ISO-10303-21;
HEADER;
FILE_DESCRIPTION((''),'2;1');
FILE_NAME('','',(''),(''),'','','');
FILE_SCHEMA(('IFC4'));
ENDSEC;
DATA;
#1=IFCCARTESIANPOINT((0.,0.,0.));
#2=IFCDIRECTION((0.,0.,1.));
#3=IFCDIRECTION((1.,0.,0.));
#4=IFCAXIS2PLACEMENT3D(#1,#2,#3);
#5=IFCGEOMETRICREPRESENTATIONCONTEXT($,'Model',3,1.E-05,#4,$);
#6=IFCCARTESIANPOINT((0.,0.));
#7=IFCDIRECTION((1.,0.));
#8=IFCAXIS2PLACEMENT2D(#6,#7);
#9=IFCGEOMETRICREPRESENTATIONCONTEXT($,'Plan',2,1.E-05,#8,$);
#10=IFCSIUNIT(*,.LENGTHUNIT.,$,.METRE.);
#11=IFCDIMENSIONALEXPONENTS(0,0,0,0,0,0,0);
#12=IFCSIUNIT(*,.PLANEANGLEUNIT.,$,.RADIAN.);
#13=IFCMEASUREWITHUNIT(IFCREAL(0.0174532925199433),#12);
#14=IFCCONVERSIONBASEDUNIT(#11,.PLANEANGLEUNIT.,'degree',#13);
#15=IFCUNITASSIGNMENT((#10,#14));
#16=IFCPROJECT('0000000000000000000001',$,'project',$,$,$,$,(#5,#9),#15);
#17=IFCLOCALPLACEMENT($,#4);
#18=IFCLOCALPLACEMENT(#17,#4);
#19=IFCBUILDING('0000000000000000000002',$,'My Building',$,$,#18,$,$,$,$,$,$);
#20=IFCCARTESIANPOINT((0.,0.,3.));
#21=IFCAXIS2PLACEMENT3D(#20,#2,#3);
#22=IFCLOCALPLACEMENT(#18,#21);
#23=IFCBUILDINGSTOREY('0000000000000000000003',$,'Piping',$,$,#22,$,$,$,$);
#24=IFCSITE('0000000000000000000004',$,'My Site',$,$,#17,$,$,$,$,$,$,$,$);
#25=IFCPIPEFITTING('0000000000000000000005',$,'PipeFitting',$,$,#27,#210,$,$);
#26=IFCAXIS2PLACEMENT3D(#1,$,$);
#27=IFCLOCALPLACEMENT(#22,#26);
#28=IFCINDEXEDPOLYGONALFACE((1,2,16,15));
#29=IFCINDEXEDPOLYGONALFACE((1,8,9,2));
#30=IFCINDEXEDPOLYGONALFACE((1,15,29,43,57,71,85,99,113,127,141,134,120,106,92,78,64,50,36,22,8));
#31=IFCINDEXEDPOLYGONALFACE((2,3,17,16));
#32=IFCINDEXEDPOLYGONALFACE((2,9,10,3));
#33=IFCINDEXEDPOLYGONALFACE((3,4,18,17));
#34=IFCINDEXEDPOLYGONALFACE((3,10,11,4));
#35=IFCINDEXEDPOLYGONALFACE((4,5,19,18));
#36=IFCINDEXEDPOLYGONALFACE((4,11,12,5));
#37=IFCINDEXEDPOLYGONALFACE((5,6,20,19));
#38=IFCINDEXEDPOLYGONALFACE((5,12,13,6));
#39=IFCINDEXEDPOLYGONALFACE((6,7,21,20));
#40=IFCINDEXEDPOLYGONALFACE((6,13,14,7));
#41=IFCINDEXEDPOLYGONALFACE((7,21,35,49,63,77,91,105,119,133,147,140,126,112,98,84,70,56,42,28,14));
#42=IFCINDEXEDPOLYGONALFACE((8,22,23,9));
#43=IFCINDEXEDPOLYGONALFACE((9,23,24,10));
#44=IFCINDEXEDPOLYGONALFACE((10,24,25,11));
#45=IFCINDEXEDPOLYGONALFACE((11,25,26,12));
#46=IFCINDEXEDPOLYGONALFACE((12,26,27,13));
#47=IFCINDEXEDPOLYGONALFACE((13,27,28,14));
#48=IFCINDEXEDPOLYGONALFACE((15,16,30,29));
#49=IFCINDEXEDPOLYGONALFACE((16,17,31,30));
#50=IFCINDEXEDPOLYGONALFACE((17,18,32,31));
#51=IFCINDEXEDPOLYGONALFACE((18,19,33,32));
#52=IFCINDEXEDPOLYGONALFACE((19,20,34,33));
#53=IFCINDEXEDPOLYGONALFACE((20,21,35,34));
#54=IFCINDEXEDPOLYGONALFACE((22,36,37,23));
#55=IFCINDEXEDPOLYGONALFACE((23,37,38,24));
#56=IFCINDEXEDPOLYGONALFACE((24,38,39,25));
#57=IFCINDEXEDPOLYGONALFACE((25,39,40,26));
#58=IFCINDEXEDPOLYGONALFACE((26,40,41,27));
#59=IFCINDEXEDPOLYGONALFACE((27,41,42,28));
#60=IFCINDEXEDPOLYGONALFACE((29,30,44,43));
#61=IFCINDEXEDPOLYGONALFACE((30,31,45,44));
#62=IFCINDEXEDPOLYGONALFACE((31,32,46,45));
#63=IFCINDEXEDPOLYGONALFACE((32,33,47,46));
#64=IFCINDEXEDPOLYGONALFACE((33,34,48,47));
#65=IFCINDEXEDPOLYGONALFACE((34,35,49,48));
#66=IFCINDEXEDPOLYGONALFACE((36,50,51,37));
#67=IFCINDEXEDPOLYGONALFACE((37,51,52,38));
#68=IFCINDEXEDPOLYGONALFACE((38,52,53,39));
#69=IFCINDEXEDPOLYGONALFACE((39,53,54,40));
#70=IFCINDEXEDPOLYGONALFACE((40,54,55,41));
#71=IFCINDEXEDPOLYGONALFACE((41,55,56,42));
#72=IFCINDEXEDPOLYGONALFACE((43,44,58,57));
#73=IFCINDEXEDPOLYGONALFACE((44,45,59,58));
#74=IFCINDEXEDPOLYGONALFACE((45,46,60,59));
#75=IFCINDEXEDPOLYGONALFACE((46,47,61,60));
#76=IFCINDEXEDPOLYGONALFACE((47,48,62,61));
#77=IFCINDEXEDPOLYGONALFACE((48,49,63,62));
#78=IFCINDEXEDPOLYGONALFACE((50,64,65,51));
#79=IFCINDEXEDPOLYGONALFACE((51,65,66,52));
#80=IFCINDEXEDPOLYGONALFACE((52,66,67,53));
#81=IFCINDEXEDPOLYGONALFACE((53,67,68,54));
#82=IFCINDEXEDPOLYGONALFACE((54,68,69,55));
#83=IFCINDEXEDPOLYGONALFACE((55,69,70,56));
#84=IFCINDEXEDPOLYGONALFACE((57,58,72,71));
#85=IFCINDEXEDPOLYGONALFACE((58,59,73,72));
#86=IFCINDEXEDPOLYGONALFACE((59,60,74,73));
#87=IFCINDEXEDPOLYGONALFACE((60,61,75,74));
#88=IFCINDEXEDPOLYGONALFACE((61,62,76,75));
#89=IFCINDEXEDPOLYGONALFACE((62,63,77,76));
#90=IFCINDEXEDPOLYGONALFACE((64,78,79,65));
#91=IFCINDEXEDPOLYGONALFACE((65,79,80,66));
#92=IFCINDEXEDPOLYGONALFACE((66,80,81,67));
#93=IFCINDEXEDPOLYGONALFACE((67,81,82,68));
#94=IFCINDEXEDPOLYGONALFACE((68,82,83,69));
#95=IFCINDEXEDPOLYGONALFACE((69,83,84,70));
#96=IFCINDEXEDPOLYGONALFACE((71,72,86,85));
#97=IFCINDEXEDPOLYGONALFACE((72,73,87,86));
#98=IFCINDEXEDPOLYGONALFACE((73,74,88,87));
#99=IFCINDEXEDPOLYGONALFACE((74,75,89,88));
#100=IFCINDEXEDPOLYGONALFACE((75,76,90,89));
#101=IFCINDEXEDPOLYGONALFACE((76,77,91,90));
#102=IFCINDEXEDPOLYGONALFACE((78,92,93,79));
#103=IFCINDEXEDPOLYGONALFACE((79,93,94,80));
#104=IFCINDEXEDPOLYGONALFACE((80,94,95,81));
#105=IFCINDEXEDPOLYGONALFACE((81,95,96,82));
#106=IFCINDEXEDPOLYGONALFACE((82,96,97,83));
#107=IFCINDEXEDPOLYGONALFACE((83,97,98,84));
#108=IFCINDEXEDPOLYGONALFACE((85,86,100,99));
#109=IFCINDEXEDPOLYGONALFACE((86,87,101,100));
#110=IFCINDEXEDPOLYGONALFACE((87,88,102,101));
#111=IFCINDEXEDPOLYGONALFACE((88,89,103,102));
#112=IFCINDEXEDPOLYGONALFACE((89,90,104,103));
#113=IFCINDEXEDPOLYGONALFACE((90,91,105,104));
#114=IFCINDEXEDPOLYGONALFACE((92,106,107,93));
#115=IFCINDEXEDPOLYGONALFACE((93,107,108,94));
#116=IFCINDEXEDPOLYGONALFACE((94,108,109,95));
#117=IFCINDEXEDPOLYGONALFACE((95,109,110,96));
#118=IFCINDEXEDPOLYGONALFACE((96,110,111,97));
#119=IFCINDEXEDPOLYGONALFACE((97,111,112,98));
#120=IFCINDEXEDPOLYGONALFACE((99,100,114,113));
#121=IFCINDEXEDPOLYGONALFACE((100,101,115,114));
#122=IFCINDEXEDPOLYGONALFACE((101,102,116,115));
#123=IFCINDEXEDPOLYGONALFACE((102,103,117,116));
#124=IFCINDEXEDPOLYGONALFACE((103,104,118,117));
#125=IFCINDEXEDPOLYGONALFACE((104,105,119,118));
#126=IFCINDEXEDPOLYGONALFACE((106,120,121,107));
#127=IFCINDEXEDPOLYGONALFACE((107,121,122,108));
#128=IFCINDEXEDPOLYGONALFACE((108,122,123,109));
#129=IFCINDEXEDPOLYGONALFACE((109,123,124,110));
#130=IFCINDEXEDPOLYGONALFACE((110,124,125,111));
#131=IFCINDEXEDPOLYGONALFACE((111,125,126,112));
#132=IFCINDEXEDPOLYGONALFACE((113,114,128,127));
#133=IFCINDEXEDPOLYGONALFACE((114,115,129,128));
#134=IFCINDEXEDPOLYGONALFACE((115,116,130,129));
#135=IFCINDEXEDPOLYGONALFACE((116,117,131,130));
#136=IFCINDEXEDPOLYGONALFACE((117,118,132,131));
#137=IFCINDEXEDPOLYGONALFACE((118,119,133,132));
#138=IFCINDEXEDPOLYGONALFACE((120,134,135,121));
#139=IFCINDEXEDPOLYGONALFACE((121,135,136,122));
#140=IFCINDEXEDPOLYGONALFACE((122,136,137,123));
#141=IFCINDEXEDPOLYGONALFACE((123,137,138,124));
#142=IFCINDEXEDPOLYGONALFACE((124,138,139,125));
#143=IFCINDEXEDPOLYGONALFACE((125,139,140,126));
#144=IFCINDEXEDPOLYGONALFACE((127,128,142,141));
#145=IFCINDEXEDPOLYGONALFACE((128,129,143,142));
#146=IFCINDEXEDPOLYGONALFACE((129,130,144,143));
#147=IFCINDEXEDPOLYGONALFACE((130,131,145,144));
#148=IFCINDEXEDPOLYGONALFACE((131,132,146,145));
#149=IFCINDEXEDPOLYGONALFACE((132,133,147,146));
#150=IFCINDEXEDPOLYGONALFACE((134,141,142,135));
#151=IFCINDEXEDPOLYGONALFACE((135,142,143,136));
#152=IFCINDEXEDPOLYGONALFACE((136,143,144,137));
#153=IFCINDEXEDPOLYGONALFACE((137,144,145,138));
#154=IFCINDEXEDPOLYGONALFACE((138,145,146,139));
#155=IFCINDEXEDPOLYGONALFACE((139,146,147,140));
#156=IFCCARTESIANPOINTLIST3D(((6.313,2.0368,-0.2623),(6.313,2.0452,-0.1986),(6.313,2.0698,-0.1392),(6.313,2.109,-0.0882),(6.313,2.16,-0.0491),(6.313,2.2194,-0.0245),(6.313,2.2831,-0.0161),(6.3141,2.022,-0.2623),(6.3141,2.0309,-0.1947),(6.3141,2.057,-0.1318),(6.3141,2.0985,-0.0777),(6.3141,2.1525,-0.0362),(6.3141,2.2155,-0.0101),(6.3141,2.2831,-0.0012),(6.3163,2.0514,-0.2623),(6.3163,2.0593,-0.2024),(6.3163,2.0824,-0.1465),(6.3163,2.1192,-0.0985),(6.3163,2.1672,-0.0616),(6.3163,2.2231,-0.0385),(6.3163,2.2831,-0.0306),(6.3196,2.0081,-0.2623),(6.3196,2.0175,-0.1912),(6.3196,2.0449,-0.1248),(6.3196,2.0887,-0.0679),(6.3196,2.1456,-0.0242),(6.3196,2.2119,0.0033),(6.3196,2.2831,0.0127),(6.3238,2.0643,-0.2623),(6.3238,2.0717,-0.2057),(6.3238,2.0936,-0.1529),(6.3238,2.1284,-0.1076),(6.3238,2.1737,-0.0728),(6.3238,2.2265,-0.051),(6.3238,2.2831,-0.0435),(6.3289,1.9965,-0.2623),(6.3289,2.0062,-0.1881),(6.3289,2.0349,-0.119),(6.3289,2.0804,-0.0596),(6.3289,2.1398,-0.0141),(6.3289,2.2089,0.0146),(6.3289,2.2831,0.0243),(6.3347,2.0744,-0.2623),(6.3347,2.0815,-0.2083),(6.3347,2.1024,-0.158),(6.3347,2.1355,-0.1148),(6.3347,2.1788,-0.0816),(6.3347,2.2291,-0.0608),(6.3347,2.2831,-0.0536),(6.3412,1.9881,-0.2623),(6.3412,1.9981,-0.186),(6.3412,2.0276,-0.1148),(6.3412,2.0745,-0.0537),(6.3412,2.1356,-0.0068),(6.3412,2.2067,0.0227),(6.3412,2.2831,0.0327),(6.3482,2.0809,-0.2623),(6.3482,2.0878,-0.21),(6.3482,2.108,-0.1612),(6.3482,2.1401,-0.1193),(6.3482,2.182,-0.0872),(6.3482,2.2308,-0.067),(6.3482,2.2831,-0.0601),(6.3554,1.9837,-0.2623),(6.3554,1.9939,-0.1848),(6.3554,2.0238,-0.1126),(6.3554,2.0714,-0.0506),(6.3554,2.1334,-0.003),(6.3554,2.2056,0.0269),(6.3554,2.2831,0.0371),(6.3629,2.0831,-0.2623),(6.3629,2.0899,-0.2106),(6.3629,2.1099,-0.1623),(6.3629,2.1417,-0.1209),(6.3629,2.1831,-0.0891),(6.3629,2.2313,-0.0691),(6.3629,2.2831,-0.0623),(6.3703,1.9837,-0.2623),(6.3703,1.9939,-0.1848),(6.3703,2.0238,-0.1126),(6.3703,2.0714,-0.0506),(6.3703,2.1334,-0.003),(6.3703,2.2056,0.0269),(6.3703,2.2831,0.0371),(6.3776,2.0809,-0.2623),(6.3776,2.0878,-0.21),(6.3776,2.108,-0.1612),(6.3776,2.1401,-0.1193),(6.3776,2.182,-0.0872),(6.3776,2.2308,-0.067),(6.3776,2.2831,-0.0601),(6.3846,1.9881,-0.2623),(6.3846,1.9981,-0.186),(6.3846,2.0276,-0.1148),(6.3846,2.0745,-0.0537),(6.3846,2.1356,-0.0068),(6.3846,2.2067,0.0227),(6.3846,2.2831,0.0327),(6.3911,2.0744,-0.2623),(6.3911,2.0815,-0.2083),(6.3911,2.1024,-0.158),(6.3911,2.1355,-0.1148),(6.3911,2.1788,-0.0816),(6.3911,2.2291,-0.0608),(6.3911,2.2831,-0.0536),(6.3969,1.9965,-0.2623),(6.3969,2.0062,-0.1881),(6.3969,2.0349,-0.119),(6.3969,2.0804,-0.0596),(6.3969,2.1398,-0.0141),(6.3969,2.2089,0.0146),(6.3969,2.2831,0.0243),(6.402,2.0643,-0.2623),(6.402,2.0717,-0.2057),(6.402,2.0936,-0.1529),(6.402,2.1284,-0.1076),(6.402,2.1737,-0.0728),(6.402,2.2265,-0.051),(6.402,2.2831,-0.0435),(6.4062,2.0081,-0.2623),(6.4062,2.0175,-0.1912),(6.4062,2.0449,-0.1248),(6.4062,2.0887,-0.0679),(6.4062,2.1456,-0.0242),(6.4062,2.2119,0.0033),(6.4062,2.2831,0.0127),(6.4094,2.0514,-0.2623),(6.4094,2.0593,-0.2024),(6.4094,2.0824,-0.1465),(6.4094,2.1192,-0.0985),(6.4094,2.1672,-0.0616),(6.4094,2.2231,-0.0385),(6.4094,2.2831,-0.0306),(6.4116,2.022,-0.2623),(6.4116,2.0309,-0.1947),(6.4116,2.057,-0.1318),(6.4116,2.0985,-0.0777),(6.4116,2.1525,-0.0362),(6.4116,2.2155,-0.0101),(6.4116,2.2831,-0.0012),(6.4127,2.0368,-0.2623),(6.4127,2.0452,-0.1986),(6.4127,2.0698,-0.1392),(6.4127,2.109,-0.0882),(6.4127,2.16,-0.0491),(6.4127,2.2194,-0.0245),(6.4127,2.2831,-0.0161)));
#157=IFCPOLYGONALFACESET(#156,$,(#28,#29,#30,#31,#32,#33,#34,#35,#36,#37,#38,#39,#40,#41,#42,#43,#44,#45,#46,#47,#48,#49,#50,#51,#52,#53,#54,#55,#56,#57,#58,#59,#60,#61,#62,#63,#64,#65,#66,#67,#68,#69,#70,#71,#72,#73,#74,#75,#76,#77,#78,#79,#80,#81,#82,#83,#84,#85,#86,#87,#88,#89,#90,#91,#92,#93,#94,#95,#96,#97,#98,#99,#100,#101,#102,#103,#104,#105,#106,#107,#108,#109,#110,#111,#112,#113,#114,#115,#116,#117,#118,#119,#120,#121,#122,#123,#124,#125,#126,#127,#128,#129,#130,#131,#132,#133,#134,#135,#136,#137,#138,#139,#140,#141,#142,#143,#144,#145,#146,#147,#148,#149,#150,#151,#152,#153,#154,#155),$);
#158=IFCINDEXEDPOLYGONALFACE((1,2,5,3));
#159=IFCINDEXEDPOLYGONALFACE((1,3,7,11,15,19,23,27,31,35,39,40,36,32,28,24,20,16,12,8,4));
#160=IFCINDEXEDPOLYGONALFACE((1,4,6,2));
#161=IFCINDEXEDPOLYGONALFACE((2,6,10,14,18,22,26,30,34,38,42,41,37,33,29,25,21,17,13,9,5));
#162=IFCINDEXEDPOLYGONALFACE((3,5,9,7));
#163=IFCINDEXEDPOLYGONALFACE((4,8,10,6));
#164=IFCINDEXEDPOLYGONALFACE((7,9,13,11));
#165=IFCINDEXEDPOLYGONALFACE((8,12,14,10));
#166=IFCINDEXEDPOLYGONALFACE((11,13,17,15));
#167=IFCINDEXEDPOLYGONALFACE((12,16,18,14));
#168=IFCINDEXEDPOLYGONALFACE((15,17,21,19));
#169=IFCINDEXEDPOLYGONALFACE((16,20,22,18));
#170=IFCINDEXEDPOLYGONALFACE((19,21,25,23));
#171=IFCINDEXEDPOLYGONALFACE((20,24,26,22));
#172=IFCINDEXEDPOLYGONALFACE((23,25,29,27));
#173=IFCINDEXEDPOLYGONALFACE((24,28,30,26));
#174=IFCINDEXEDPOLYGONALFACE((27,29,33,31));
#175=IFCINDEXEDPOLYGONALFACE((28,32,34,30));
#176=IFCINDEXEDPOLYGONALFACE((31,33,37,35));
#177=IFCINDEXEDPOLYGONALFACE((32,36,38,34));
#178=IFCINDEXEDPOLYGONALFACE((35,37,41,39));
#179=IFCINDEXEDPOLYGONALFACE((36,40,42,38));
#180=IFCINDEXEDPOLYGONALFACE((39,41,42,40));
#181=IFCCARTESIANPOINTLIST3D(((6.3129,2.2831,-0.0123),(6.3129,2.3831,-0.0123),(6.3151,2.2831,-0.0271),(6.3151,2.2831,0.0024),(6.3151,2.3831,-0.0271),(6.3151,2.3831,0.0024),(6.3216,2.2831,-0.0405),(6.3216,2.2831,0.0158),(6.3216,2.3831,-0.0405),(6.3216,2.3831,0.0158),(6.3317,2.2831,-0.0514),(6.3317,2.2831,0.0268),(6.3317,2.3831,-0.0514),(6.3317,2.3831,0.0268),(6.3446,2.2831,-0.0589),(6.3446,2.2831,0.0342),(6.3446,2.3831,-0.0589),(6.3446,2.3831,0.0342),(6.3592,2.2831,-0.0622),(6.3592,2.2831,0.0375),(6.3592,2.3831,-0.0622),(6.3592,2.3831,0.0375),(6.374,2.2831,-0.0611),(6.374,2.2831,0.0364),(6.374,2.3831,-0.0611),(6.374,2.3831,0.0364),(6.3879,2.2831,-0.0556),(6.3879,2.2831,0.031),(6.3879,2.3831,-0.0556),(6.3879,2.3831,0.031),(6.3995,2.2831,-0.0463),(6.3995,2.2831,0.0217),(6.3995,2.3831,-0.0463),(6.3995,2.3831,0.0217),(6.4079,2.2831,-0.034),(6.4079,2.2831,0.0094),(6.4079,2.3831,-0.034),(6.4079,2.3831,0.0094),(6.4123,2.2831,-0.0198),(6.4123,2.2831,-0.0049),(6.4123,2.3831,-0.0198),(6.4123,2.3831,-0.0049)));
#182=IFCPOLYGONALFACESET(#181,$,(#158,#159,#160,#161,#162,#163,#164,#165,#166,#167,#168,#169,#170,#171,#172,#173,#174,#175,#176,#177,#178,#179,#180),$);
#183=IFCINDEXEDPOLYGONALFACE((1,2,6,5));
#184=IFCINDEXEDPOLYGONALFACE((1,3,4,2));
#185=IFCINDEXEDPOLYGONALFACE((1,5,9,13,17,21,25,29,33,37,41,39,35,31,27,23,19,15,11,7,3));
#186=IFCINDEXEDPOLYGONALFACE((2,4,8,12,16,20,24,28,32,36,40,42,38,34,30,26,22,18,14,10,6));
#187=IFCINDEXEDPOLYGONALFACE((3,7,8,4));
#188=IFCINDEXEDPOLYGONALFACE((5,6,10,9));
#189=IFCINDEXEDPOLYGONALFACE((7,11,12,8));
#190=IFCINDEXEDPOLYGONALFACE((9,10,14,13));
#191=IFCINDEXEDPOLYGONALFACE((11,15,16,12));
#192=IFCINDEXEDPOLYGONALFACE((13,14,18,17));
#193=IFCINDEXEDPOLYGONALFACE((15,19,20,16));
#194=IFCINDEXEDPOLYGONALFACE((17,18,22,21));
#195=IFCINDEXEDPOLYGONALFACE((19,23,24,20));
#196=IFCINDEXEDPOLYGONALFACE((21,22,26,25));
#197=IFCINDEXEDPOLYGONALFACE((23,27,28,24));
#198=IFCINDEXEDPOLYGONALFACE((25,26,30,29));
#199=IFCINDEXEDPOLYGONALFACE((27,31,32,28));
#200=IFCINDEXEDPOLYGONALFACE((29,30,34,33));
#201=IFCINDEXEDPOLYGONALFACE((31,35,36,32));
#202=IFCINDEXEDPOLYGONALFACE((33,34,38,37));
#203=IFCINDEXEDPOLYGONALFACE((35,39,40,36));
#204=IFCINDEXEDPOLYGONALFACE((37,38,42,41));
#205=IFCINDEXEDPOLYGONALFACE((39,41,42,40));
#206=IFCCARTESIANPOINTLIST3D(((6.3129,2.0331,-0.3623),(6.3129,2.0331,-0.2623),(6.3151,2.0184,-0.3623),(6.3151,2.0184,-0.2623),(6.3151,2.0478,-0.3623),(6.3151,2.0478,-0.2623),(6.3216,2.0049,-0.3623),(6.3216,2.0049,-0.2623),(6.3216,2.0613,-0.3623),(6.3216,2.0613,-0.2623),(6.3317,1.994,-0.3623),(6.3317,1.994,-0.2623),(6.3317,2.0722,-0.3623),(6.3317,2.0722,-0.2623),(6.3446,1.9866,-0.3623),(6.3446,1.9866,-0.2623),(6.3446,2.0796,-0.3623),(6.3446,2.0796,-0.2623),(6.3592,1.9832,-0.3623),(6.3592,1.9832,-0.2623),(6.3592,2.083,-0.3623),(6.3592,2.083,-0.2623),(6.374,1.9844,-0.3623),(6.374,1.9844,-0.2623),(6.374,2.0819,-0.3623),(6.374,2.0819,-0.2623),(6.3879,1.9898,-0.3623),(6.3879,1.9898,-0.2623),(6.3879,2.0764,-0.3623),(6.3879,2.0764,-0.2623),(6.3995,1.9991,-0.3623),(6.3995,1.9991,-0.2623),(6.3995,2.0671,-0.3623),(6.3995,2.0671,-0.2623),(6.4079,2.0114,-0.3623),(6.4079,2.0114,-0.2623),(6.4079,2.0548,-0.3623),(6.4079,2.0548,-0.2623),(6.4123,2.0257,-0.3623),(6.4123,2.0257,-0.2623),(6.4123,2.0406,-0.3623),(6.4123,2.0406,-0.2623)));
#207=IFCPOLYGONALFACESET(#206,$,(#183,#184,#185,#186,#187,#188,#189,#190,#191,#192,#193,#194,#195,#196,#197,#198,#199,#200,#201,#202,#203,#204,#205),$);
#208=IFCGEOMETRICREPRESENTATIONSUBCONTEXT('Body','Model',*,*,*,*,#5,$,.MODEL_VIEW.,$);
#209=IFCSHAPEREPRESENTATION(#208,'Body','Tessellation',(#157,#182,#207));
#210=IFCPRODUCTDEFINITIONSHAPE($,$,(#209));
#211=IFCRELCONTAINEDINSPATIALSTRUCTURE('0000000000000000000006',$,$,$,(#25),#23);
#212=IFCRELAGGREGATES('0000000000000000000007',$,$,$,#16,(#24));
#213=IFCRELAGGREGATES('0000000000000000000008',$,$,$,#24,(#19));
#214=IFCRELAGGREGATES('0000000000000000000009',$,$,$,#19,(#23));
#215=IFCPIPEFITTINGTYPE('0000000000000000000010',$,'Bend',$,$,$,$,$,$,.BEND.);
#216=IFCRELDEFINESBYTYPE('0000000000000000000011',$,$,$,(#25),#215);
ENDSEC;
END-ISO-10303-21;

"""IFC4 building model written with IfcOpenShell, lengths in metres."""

from ifc_helpers import new_model, entity, si_unit, converted_unit, frame, origin_with_axes, origin_2d_with_axis, place, context, subcontext, project, spatial, circle, extrude, source, transform, mapped, type_object, type_shapes, element, save


model = new_model("IFC4")

# Units and contexts
model_context = context("Model", 3, precision=1e-05, world=origin_with_axes())
plan_context = context("Plan", 2, precision=1e-05, world=origin_2d_with_axis())
body_context = subcontext(model_context, "Body", "Model", "MODEL_VIEW")
ifc_project = project(units=[si_unit("LENGTHUNIT", "METRE"), converted_unit("PLANEANGLEUNIT", "degree", entity("IfcReal", 0.0174532925199433), si_unit("PLANEANGLEUNIT", "RADIAN"), dimensions=[0, 0, 0, 0, 0, 0, 0])], contexts=[model_context, plan_context])

# Site, building, storey
site_placement = place(None, origin_with_axes())
site = spatial("IfcSite", under=ifc_project, at=site_placement, Name="My Site")
building_placement = place(site_placement, origin_with_axes())
building = spatial("IfcBuilding", under=site, at=building_placement, Name="My Building")
storey_placement = place(building_placement, frame((0.0, 0.0, 3.0), z_axis=(0.0, 0.0, 1.0), x_axis=(1.0, 0.0, 0.0)))
storey = spatial("IfcBuildingStorey", under=building, at=storey_placement, Name="Piping")

# Pipe fitting
pipe_fitting_type = type_object("IfcPipeFittingType", Name="Bend", PredefinedType="BEND")
shared_shape = source(origin_with_axes(), body_context, "Body", "SolidModel", [
    entity("IfcSweptDiskSolid", entity("IfcIndexedPolyCurve", entity("IfcCartesianPointList3D", [[0.0, 0.0, -0.1], [0.0, -0.0732, -0.2768], [0.0, -0.25, -0.35]]), [entity("IfcArcIndex", [1, 2, 3])]), 0.05),
    extrude(circle(Radius=0.05), origin_with_axes(), (0.0, 0.0, -1.0), 0.1),
    extrude(circle(Radius=0.05), frame((0.0, -0.25, -0.35), z_axis=(0.0, -1.0, 0.0), x_axis=(1.0, 0.0, 0.0)), (0.0, 0.0, 1.0), 0.1),
])
type_shapes(pipe_fitting_type, [shared_shape])
for number, where, z_axis, x_axis, name in (
    (1, (6.3629, 2.3831, -0.0123), (0.0, 1.0, 0.0), (-1.0, 0.0, 0.0), "PipeFitting"),
):
    element("IfcPipeFitting", number, at=place(storey_placement, frame(where, z_axis=z_axis, x_axis=x_axis)), inside=storey, type_object=pipe_fitting_type, Name=name, context=body_context, shape_type="MappedRepresentation", body=[
        mapped(shared_shape, transform((0.0, 0.0, 0.0), x_axis=(1.0, 0.0, 0.0), y_axis=(0.0, 1.0, 0.0), z_axis=(0.0, 0.0, 1.0), scale=1.0)),
    ])

save(model, "model.ifc")
